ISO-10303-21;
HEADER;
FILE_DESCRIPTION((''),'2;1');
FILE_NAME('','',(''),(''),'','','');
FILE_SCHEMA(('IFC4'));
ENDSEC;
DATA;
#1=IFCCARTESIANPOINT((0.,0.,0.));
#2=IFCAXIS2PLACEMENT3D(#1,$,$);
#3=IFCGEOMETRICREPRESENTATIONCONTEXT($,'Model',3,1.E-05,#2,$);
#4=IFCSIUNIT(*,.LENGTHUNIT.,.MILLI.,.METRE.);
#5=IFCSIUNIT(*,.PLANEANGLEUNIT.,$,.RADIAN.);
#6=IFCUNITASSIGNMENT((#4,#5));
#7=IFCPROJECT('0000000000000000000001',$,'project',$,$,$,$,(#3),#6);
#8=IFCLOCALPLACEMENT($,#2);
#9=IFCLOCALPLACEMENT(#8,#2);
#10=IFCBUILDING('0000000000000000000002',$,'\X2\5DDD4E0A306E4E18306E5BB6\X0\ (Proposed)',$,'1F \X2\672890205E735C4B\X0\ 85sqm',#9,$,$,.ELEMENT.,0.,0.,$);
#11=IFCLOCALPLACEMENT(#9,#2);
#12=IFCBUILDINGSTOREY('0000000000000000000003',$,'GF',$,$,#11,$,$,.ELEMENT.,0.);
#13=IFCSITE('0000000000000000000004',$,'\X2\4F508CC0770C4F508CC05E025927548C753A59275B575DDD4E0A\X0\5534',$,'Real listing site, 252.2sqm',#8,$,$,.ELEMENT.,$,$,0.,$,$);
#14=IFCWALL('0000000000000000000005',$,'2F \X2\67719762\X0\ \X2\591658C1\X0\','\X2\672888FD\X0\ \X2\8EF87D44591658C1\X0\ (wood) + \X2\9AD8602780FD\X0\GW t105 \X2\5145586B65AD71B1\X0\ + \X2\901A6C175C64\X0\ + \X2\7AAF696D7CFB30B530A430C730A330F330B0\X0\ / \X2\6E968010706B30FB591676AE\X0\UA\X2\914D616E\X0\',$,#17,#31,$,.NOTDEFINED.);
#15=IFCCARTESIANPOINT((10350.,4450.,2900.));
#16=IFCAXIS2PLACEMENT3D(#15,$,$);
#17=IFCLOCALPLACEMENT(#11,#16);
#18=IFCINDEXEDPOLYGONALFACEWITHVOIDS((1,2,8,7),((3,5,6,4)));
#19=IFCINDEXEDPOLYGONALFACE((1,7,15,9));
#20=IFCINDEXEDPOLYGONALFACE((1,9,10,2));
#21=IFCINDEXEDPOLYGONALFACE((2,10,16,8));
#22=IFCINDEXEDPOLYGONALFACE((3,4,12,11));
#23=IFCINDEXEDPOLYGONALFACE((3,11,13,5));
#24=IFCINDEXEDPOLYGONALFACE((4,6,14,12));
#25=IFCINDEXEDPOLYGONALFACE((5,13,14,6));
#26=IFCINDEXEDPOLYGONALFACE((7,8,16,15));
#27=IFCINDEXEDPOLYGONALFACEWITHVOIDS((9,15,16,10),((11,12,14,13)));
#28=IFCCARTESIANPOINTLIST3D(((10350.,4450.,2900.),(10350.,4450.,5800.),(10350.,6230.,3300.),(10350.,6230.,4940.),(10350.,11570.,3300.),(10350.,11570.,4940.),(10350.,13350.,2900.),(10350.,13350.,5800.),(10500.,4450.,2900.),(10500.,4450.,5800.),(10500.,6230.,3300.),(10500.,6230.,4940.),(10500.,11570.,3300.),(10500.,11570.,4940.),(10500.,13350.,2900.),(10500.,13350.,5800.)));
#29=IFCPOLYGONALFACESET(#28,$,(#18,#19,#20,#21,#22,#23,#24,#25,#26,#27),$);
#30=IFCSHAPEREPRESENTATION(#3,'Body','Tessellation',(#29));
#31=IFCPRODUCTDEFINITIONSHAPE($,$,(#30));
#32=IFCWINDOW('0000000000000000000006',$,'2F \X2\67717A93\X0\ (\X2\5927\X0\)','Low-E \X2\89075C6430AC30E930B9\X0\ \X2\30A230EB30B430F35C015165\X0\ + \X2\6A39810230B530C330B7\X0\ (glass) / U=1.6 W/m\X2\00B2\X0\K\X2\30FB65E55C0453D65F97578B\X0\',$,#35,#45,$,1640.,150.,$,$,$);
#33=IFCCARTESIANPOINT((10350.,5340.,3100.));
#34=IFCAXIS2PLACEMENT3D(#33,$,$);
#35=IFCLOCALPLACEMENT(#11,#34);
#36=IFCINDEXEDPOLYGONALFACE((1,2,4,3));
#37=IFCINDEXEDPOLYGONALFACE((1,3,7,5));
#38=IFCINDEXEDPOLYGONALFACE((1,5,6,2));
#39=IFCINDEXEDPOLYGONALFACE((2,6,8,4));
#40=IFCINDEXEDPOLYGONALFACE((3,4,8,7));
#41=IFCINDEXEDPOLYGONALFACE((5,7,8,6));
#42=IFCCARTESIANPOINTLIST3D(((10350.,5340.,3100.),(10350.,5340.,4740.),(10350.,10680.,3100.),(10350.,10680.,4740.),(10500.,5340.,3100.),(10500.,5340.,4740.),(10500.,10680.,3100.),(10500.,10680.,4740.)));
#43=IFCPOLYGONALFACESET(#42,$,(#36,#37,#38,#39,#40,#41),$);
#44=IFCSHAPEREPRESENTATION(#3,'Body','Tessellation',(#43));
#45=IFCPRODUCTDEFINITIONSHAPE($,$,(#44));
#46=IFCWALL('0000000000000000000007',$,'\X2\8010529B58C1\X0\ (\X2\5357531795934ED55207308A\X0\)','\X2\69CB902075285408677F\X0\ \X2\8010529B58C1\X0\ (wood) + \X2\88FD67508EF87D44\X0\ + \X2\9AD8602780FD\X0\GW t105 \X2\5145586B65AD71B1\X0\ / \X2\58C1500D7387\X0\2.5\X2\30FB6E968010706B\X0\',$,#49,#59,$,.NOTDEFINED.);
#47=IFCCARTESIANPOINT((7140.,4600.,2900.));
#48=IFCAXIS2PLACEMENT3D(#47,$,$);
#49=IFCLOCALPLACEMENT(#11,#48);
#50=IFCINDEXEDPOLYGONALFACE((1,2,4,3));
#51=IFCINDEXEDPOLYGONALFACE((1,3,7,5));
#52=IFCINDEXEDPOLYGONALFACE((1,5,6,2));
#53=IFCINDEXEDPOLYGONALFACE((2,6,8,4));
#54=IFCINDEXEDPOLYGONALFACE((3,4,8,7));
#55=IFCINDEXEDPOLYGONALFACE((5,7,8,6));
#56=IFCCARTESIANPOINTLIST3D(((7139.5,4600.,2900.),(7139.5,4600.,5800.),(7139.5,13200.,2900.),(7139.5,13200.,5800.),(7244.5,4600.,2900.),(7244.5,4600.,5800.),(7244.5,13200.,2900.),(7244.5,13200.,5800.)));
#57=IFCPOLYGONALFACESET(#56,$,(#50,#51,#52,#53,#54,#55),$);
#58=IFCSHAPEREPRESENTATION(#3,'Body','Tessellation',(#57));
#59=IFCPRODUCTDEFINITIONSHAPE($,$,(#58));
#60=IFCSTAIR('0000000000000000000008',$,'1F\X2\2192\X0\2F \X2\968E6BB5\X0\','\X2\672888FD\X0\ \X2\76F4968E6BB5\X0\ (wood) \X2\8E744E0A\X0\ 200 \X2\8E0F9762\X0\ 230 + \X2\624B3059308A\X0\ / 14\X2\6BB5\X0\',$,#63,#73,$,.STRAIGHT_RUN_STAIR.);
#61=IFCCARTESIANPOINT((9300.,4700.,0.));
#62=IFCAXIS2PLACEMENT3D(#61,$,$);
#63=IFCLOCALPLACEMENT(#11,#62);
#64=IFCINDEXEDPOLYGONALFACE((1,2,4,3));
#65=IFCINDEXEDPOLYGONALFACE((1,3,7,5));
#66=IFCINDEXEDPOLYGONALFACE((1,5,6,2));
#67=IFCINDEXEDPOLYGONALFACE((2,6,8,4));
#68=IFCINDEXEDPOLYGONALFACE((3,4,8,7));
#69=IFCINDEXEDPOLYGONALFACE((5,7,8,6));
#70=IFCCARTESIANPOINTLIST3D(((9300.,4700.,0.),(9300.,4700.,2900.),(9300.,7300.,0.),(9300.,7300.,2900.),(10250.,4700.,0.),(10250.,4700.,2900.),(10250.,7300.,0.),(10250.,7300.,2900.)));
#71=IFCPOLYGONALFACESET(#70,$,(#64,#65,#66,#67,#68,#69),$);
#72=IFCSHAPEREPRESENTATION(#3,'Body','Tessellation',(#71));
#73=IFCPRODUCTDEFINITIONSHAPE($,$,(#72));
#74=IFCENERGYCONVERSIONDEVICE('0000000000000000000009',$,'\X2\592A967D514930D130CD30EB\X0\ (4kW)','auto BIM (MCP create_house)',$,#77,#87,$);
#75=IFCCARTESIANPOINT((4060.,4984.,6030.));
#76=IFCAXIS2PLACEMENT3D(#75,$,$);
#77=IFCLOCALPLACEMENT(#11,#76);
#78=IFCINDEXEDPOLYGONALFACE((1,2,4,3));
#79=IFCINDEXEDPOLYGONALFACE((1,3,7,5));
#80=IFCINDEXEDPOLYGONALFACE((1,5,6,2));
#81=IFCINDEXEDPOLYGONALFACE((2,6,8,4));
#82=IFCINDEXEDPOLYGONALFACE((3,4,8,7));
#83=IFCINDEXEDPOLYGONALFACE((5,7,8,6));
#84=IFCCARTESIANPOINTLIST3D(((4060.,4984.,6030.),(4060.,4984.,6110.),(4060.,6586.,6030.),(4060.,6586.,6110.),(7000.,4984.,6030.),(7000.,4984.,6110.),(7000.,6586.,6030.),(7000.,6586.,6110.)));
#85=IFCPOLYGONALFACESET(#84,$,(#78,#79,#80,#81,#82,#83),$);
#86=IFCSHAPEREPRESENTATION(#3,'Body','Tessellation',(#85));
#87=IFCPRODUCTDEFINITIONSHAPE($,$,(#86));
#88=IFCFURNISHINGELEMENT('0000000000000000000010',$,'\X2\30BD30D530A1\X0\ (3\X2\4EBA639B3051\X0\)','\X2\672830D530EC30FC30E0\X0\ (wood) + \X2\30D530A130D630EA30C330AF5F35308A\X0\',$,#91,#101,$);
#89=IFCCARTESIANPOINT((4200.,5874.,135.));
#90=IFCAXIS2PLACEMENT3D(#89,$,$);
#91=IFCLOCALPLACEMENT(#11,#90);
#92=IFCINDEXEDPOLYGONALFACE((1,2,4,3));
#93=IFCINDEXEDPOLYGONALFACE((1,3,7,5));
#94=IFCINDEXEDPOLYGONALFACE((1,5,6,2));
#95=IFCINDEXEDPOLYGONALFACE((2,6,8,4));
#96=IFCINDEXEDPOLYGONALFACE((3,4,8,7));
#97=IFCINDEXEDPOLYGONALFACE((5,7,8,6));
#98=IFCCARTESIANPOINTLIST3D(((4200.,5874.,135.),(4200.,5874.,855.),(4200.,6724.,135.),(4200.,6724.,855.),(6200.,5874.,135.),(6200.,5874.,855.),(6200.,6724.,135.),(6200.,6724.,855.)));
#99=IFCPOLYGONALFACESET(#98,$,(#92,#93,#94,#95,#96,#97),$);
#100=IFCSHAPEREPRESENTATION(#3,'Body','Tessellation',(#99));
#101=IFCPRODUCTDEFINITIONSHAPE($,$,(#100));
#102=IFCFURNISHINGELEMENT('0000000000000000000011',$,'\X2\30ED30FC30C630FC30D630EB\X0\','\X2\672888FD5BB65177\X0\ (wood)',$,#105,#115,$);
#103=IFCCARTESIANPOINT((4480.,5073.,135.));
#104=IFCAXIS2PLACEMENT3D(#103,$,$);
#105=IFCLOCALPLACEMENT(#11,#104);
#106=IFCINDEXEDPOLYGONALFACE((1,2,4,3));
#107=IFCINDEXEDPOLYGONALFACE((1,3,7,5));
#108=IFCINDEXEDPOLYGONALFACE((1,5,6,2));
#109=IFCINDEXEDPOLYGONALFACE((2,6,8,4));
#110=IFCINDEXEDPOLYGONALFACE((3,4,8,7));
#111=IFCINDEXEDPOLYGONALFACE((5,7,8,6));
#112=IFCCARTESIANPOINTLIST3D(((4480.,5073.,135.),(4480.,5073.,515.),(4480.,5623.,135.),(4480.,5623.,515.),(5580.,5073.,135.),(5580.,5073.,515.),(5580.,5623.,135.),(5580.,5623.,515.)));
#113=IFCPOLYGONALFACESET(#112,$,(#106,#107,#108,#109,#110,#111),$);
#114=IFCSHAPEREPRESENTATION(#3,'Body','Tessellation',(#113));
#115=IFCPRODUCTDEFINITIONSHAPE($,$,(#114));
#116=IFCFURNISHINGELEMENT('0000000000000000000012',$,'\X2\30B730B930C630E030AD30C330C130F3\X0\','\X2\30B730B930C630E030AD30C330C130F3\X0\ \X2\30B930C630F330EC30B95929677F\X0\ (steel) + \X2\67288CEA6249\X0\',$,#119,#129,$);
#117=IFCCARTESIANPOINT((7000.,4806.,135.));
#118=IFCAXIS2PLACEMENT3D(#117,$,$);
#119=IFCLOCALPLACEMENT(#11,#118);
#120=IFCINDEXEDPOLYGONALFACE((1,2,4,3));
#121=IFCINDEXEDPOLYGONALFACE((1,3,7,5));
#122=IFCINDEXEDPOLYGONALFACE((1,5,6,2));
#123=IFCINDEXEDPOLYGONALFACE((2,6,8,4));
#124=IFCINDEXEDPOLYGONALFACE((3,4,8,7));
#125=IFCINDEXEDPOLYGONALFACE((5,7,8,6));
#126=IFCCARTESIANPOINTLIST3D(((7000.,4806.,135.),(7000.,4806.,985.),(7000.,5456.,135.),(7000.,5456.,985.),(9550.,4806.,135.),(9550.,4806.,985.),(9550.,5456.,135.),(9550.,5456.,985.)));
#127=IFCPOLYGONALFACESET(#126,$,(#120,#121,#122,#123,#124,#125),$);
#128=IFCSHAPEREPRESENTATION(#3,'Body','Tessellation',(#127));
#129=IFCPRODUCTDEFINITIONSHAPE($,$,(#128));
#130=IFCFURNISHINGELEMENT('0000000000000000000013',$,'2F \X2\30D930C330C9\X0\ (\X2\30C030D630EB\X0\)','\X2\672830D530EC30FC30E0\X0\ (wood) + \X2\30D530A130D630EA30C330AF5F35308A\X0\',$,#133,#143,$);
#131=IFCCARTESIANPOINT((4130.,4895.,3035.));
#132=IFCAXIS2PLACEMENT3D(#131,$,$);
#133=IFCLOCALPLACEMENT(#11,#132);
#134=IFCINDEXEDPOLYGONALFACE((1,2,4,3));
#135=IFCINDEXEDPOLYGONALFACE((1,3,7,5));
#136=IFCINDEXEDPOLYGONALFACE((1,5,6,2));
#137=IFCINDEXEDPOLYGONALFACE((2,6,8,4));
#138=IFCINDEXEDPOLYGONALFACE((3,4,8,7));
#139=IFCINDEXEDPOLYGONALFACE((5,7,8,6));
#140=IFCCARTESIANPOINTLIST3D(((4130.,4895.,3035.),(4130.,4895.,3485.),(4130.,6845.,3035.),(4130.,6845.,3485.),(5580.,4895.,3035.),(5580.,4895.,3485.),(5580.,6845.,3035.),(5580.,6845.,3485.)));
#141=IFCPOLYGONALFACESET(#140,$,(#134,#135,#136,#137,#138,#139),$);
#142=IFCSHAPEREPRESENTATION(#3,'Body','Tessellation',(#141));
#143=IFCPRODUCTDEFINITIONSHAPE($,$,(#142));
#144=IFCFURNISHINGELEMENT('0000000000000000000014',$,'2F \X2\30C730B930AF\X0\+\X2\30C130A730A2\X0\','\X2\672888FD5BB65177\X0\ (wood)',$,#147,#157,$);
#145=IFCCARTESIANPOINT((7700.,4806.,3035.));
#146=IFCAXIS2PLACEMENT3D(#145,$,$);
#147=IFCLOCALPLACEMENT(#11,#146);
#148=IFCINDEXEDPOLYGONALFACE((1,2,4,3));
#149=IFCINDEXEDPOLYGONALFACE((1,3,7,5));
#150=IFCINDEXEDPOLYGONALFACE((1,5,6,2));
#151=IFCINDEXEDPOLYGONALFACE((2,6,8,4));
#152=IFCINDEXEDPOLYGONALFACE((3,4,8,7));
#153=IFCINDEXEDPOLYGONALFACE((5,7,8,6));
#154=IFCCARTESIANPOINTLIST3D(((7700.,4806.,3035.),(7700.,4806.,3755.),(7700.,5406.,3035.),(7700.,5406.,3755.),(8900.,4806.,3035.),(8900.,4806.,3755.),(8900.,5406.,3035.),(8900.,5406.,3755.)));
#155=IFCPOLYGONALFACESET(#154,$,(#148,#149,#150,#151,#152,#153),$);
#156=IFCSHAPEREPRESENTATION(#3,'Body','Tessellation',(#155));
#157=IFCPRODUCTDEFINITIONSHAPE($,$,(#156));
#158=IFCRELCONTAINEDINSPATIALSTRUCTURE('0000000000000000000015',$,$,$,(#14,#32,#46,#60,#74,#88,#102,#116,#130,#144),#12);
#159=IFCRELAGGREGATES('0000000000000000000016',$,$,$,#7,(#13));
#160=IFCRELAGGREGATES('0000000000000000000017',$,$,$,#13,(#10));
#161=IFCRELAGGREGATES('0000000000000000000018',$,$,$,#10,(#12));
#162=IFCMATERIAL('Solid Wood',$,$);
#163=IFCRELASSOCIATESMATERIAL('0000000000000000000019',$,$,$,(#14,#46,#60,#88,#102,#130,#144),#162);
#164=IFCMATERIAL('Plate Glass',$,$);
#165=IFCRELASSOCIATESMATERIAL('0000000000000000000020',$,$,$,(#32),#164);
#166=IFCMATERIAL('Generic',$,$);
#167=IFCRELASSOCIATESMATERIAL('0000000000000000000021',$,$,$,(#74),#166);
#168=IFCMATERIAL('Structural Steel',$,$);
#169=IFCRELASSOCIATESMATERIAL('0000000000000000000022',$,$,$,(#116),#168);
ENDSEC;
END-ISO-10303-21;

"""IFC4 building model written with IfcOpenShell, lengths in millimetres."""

from ifc_helpers import new_model, si_unit, frame, frame_2d, origin, place, context, project, spatial, rectangle, extrude, material, element, fill, save


model = new_model("IFC4")

# Units and contexts
model_context = context("Model", 3, precision=1e-05, world=origin())
ifc_project = project(units=[si_unit("LENGTHUNIT", "METRE", prefix="MILLI"), si_unit("PLANEANGLEUNIT", "RADIAN")], contexts=[model_context])

# Site, building, storey
site_placement = place(None, origin())
site = spatial("IfcSite", under=ifc_project, at=site_placement, Name="佐賀県佐賀市大和町大字川上5534", ObjectType="Real listing site, 252.2sqm", CompositionType="ELEMENT", RefElevation=0.0)
building_placement = place(site_placement, origin())
building = spatial("IfcBuilding", under=site, at=building_placement, Name="川上の丘の家 (Proposed)", ObjectType="1F 木造平屋 85sqm", CompositionType="ELEMENT", ElevationOfRefHeight=0.0, ElevationOfTerrain=0.0)
storey_placement = place(building_placement, origin())
storey = spatial("IfcBuildingStorey", under=building, at=storey_placement, Name="GF", CompositionType="ELEMENT", Elevation=0.0)

# Shared definitions
ifc_material_1 = material(Name="Solid Wood")
ifc_material_2 = material(Name="Plate Glass")

# Wall, opening, window
wall_1_placement = place(storey_placement, frame((10350.0, 4450.0, 2900.0)))
wall_1 = element("IfcWall", 1, at=wall_1_placement, inside=storey, material=ifc_material_1, Name="2F 東面 外壁", Description="木製 軸組外壁 (wood) + 高性能GW t105 充填断熱 + 通気層 + 窯業系サイディング / 準耐火・外皮UA配慮", PredefinedType="NOTDEFINED", context=model_context, shape_type="SweptSolid", body=[
    extrude(rectangle(XDim=150.0, YDim=8900.0, at=frame_2d((75.0, 4450.0))), frame((10350.0, 4450.0, 2900.0)), (0.0, 0.0, 1.0), 2900.0),
])
opening_1_placement = place(storey_placement, frame((10350.0, 5340.0, 3100.0)))
opening_1 = element("IfcOpeningElement", 2, at=opening_1_placement, cuts=wall_1, PredefinedType="NOTDEFINED", context=model_context, shape_type="SweptSolid", body=[
    extrude(rectangle(XDim=150.0, YDim=5340.0, at=frame_2d((75.0, 2670.0))), frame((10350.0, 5340.0, 3100.0)), (0.0, 0.0, 1.0), 1640.0),
])
window_1_placement = place(storey_placement, frame((10350.0, 5340.0, 3100.0)))
window_1 = element("IfcWindow", 3, at=window_1_placement, inside=storey, material=ifc_material_2, Name="2F 東窓 (大)", Description="Low-E 複層ガラス アルゴン封入 + 樹脂サッシ (glass) / U=1.6 W/m²K・日射取得型", OverallHeight=1640.0, OverallWidth=150.0, context=model_context, shape_type="SweptSolid", body=[
    extrude(rectangle(XDim=150.0, YDim=5340.0, at=frame_2d((75.0, 2670.0))), frame((10350.0, 5340.0, 3100.0)), (0.0, 0.0, 1.0), 1640.0),
])
fill(opening_1, window_1)

# Wall
wall_2_placement = place(storey_placement, frame((7140.0, 4600.0, 2900.0)))
element("IfcWall", 4, at=wall_2_placement, inside=storey, material=ifc_material_1, Name="耐力壁 (南北間仕切り)", Description="構造用合板 耐力壁 (wood) + 製材軸組 + 高性能GW t105 充填断熱 / 壁倍率2.5・準耐火", PredefinedType="NOTDEFINED", context=model_context, shape_type="SweptSolid", body=[
    extrude(rectangle(XDim=105.0, YDim=8600.0, at=frame_2d((52.0, 4300.0))), frame((7140.0, 4600.0, 2900.0)), (0.0, 0.0, 1.0), 2900.0),
])

# Stair
stair_placement = place(storey_placement, frame((9300.0, 4700.0, 0.0)))
element("IfcStair", 5, at=stair_placement, inside=storey, material=ifc_material_1, Name="1F→2F 階段", Description="木製 直階段 (wood) 蹴上 200 踏面 230 + 手すり / 14段", PredefinedType="STRAIGHT_RUN_STAIR", context=model_context, shape_type="SweptSolid", body=[
    extrude(rectangle(XDim=950.0, YDim=2600.0, at=frame_2d((475.0, 1300.0))), frame((9300.0, 4700.0, 0.0)), (0.0, 0.0, 1.0), 2900.0),
])

# Energy conversion device
ifc_material_3 = material(Name="Generic")
energy_conversion_device_placement = place(storey_placement, frame((4060.0, 4984.0, 6030.0)))
element("IfcEnergyConversionDevice", 6, at=energy_conversion_device_placement, inside=storey, material=ifc_material_3, Name="太陽光パネル (4kW)", Description="auto BIM (MCP create_house)", context=model_context, shape_type="SweptSolid", body=[
    extrude(rectangle(XDim=2940.0, YDim=1602.0, at=frame_2d((1470.0, 801.0))), frame((4060.0, 4984.0, 6030.0)), (0.0, 0.0, 1.0), 80.0),
])

# Furnishing elements
furnishing_1_placement = place(storey_placement, frame((4200.0, 5874.0, 135.0)))
element("IfcFurnishingElement", 7, at=furnishing_1_placement, inside=storey, material=ifc_material_1, Name="ソファ (3人掛け)", Description="木フレーム (wood) + ファブリック張り", context=model_context, shape_type="SweptSolid", body=[
    extrude(rectangle(XDim=2000.0, YDim=850.0, at=frame_2d((1000.0, 425.0))), frame((4200.0, 5874.0, 135.0)), (0.0, 0.0, 1.0), 720.0),
])
furnishing_2_placement = place(storey_placement, frame((4480.0, 5073.0, 135.0)))
element("IfcFurnishingElement", 8, at=furnishing_2_placement, inside=storey, material=ifc_material_1, Name="ローテーブル", Description="木製家具 (wood)", context=model_context, shape_type="SweptSolid", body=[
    extrude(rectangle(XDim=1100.0, YDim=550.0, at=frame_2d((550.0, 275.0))), frame((4480.0, 5073.0, 135.0)), (0.0, 0.0, 1.0), 380.0),
])
ifc_material_4 = material(Name="Structural Steel")
furnishing_3_placement = place(storey_placement, frame((7000.0, 4806.0, 135.0)))
element("IfcFurnishingElement", 9, at=furnishing_3_placement, inside=storey, material=ifc_material_4, Name="システムキッチン", Description="システムキッチン ステンレス天板 (steel) + 木質扉", context=model_context, shape_type="SweptSolid", body=[
    extrude(rectangle(XDim=2550.0, YDim=650.0, at=frame_2d((1275.0, 325.0))), frame((7000.0, 4806.0, 135.0)), (0.0, 0.0, 1.0), 850.0),
])
furnishing_4_placement = place(storey_placement, frame((4130.0, 4895.0, 3035.0)))
element("IfcFurnishingElement", 10, at=furnishing_4_placement, inside=storey, material=ifc_material_1, Name="2F ベッド (ダブル)", Description="木フレーム (wood) + ファブリック張り", context=model_context, shape_type="SweptSolid", body=[
    extrude(rectangle(XDim=1450.0, YDim=1950.0, at=frame_2d((725.0, 975.0))), frame((4130.0, 4895.0, 3035.0)), (0.0, 0.0, 1.0), 450.0),
])
furnishing_5_placement = place(storey_placement, frame((7700.0, 4806.0, 3035.0)))
element("IfcFurnishingElement", 11, at=furnishing_5_placement, inside=storey, material=ifc_material_1, Name="2F デスク+チェア", Description="木製家具 (wood)", context=model_context, shape_type="SweptSolid", body=[
    extrude(rectangle(XDim=1200.0, YDim=600.0, at=frame_2d((600.0, 300.0))), frame((7700.0, 4806.0, 3035.0)), (0.0, 0.0, 1.0), 720.0),
])

save(model, "model.ifc")
